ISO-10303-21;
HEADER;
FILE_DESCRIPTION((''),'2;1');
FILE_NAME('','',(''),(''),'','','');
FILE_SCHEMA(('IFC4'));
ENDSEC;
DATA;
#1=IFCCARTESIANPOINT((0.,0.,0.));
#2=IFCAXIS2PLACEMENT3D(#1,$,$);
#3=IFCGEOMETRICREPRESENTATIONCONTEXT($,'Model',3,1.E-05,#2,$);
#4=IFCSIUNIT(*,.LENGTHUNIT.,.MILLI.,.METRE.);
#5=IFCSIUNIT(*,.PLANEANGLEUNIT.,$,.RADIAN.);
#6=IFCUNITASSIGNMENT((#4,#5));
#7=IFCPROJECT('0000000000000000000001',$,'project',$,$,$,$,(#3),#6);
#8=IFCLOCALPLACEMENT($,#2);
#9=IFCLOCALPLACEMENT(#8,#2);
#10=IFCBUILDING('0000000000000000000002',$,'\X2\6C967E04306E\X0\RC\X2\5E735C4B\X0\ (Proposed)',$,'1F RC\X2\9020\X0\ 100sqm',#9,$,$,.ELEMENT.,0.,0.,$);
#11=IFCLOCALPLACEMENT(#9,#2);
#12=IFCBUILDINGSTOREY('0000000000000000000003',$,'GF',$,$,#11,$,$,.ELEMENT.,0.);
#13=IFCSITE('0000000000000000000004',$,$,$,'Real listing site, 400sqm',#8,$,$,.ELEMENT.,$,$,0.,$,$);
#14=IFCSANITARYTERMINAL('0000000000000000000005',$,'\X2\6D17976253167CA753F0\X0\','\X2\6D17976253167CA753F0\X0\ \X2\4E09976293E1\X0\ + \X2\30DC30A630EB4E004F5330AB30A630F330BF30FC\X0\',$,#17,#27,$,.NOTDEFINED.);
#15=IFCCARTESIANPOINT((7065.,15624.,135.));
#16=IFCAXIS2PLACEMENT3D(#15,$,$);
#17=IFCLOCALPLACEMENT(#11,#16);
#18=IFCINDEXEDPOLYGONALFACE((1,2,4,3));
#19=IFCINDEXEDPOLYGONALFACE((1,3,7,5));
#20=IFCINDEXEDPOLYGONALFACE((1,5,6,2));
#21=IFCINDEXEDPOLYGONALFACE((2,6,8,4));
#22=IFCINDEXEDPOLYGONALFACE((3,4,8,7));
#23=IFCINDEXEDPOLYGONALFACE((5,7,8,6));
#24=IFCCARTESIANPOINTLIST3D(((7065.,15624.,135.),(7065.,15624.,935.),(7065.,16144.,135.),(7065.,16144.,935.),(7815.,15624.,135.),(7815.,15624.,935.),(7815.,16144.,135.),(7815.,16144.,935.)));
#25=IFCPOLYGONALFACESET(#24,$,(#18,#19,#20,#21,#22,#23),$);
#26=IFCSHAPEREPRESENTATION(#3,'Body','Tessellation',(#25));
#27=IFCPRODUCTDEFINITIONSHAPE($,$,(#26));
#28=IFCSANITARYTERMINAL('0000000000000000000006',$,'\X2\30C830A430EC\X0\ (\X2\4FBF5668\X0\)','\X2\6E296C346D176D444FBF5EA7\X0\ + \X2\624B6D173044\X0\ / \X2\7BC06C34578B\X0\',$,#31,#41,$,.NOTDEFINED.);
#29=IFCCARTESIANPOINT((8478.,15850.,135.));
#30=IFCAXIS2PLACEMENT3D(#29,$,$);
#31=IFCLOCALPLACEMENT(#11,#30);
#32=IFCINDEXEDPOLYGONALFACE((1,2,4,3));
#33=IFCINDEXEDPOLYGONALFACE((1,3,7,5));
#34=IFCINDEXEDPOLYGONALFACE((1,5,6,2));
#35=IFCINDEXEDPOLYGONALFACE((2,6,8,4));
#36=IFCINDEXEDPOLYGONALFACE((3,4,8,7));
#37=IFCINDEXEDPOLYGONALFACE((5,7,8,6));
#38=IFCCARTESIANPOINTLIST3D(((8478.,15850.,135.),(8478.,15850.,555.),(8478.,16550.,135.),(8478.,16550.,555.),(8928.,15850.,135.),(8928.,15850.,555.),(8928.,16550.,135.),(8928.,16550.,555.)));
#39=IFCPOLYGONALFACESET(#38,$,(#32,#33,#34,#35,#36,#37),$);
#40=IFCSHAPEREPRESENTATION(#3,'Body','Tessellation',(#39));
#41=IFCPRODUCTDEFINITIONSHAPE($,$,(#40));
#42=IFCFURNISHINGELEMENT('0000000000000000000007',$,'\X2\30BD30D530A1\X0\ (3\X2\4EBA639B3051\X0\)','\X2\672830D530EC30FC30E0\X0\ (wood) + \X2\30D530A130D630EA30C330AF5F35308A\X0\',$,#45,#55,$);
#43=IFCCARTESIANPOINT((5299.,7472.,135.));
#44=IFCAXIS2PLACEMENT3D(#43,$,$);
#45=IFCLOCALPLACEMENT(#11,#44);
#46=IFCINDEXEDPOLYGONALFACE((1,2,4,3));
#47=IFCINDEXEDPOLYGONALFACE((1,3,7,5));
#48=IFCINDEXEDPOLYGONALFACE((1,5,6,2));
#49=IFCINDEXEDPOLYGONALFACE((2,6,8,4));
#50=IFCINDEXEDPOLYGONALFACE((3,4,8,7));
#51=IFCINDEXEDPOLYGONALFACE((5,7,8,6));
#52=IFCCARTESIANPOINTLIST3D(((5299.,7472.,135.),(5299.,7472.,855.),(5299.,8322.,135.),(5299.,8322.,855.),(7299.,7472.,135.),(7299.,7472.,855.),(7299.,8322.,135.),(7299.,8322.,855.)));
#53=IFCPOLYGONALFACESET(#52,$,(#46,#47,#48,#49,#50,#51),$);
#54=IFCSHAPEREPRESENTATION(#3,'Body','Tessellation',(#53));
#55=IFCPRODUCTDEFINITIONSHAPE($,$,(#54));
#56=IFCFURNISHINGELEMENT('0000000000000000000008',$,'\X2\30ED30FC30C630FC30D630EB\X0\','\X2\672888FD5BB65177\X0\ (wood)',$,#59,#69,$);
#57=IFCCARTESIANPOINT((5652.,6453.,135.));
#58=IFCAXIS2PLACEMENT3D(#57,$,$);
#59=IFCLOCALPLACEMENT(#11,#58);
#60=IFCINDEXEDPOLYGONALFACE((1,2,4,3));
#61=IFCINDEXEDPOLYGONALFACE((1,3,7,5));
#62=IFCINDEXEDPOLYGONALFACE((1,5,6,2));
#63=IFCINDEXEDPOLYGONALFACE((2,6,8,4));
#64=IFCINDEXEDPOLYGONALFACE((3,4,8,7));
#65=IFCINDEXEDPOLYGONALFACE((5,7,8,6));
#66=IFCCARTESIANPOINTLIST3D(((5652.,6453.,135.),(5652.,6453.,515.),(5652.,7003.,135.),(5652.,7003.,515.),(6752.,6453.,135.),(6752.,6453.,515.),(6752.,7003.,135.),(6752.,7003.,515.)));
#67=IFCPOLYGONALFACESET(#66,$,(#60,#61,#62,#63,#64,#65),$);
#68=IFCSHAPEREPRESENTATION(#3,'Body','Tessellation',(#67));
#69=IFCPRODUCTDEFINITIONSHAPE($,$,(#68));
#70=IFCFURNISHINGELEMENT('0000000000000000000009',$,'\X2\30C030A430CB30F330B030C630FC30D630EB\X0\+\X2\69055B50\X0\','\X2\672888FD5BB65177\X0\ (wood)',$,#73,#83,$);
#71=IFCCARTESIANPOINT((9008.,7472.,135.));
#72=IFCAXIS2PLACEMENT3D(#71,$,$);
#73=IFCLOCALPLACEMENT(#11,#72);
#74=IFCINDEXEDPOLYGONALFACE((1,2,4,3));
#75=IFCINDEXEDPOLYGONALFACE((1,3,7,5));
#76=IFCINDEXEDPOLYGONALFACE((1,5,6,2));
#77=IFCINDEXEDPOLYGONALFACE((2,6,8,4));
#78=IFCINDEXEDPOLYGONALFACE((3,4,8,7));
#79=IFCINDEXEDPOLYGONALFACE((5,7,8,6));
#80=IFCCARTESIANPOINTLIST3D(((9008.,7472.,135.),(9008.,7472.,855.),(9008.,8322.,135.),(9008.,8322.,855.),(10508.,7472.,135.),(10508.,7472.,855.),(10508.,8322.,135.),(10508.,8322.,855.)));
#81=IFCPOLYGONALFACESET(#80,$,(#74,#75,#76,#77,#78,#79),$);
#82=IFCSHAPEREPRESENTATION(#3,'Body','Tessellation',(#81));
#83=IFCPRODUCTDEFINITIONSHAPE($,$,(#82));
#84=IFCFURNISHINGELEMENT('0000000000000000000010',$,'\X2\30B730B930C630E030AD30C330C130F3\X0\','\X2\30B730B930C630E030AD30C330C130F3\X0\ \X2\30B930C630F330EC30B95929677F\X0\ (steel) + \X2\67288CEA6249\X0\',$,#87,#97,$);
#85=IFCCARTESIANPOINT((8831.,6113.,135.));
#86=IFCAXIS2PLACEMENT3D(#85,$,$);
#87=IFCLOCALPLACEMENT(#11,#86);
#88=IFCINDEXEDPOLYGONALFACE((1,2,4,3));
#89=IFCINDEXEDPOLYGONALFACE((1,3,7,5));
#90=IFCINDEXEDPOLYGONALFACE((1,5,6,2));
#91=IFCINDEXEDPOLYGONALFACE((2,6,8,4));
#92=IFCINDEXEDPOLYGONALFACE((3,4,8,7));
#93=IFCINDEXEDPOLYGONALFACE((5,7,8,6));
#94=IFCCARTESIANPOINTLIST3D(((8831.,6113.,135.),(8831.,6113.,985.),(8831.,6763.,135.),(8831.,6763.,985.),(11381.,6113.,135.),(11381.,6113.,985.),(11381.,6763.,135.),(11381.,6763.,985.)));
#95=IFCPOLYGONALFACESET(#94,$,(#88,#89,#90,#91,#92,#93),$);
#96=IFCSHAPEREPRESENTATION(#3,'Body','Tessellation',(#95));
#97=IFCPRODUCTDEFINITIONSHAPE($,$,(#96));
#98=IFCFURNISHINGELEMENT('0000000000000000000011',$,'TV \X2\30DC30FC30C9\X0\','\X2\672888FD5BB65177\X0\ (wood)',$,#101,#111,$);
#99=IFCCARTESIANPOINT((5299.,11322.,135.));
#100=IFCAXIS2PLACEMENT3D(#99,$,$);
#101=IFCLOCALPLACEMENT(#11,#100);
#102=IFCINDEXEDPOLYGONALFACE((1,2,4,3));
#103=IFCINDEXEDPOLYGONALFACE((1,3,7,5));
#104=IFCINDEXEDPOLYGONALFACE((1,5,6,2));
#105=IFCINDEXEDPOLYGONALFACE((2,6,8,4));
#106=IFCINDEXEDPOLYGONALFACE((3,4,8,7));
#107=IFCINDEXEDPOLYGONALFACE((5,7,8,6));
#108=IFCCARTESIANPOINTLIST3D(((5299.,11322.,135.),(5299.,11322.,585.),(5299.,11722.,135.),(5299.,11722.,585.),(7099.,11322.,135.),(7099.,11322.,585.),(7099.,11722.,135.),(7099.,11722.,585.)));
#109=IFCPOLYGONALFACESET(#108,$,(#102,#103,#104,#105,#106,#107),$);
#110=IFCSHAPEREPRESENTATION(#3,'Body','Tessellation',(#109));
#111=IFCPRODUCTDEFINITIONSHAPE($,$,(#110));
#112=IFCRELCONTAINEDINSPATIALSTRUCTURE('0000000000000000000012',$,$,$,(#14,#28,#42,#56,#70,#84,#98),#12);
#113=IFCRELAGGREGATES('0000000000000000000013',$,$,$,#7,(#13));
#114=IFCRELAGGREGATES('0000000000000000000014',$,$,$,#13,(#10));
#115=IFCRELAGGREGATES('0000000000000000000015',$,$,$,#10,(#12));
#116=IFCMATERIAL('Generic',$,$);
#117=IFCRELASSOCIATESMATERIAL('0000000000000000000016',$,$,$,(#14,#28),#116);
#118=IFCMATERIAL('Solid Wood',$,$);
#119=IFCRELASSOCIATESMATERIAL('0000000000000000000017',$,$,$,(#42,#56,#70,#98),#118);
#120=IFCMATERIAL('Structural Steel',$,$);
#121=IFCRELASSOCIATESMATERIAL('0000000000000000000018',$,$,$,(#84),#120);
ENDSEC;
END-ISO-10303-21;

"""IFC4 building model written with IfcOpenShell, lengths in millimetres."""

from ifc_helpers import new_model, si_unit, frame, frame_2d, origin, place, context, project, spatial, rectangle, extrude, material, element, save


model = new_model("IFC4")

# Units and contexts
model_context = context("Model", 3, precision=1e-05, world=origin())
ifc_project = project(units=[si_unit("LENGTHUNIT", "METRE", prefix="MILLI"), si_unit("PLANEANGLEUNIT", "RADIAN")], contexts=[model_context])

# Site, building, storey
site_placement = place(None, origin())
site = spatial("IfcSite", under=ifc_project, at=site_placement, ObjectType="Real listing site, 400sqm", CompositionType="ELEMENT", RefElevation=0.0)
building_placement = place(site_placement, origin())
building = spatial("IfcBuilding", under=site, at=building_placement, Name="沖縄のRC平屋 (Proposed)", ObjectType="1F RC造 100sqm", CompositionType="ELEMENT", ElevationOfRefHeight=0.0, ElevationOfTerrain=0.0)
storey_placement = place(building_placement, origin())
storey = spatial("IfcBuildingStorey", under=building, at=storey_placement, Name="GF", CompositionType="ELEMENT", Elevation=0.0)

# Shared definitions
ifc_material_1 = material(Name="Solid Wood")

# Shared definitions
ifc_material_2 = material(Name="Structural Steel")

# Shared definitions
ifc_material_3 = material(Name="Generic")

# Sanitary terminals
sanitary_terminal_1_placement = place(storey_placement, frame((7065.0, 15624.0, 135.0)))
element("IfcSanitaryTerminal", 1, at=sanitary_terminal_1_placement, inside=storey, material=ifc_material_3, Name="洗面化粧台", Description="洗面化粧台 三面鏡 + ボウル一体カウンター", PredefinedType="NOTDEFINED", context=model_context, shape_type="SweptSolid", body=[
    extrude(rectangle(XDim=750.0, YDim=520.0, at=frame_2d((375.0, 260.0))), frame((7065.0, 15624.0, 135.0)), (0.0, 0.0, 1.0), 800.0),
])
sanitary_terminal_2_placement = place(storey_placement, frame((8478.0, 15850.0, 135.0)))
element("IfcSanitaryTerminal", 2, at=sanitary_terminal_2_placement, inside=storey, material=ifc_material_3, Name="トイレ (便器)", Description="温水洗浄便座 + 手洗い / 節水型", PredefinedType="NOTDEFINED", context=model_context, shape_type="SweptSolid", body=[
    extrude(rectangle(XDim=450.0, YDim=700.0, at=frame_2d((225.0, 350.0))), frame((8478.0, 15850.0, 135.0)), (0.0, 0.0, 1.0), 420.0),
])

# Furnishing elements
furnishing_1_placement = place(storey_placement, frame((5299.0, 7472.0, 135.0)))
element("IfcFurnishingElement", 3, at=furnishing_1_placement, inside=storey, material=ifc_material_1, Name="ソファ (3人掛け)", Description="木フレーム (wood) + ファブリック張り", context=model_context, shape_type="SweptSolid", body=[
    extrude(rectangle(XDim=2000.0, YDim=850.0, at=frame_2d((1000.0, 425.0))), frame((5299.0, 7472.0, 135.0)), (0.0, 0.0, 1.0), 720.0),
])
furnishing_2_placement = place(storey_placement, frame((5652.0, 6453.0, 135.0)))
element("IfcFurnishingElement", 4, at=furnishing_2_placement, inside=storey, material=ifc_material_1, Name="ローテーブル", Description="木製家具 (wood)", context=model_context, shape_type="SweptSolid", body=[
    extrude(rectangle(XDim=1100.0, YDim=550.0, at=frame_2d((550.0, 275.0))), frame((5652.0, 6453.0, 135.0)), (0.0, 0.0, 1.0), 380.0),
])
furnishing_3_placement = place(storey_placement, frame((9008.0, 7472.0, 135.0)))
element("IfcFurnishingElement", 5, at=furnishing_3_placement, inside=storey, material=ifc_material_1, Name="ダイニングテーブル+椅子", Description="木製家具 (wood)", context=model_context, shape_type="SweptSolid", body=[
    extrude(rectangle(XDim=1500.0, YDim=850.0, at=frame_2d((750.0, 425.0))), frame((9008.0, 7472.0, 135.0)), (0.0, 0.0, 1.0), 720.0),
])
furnishing_4_placement = place(storey_placement, frame((8831.0, 6113.0, 135.0)))
element("IfcFurnishingElement", 6, at=furnishing_4_placement, inside=storey, material=ifc_material_2, Name="システムキッチン", Description="システムキッチン ステンレス天板 (steel) + 木質扉", context=model_context, shape_type="SweptSolid", body=[
    extrude(rectangle(XDim=2550.0, YDim=650.0, at=frame_2d((1275.0, 325.0))), frame((8831.0, 6113.0, 135.0)), (0.0, 0.0, 1.0), 850.0),
])
furnishing_5_placement = place(storey_placement, frame((5299.0, 11322.0, 135.0)))
element("IfcFurnishingElement", 7, at=furnishing_5_placement, inside=storey, material=ifc_material_1, Name="TV ボード", Description="木製家具 (wood)", context=model_context, shape_type="SweptSolid", body=[
    extrude(rectangle(XDim=1800.0, YDim=400.0, at=frame_2d((900.0, 200.0))), frame((5299.0, 11322.0, 135.0)), (0.0, 0.0, 1.0), 450.0),
])

save(model, "model.ifc")
